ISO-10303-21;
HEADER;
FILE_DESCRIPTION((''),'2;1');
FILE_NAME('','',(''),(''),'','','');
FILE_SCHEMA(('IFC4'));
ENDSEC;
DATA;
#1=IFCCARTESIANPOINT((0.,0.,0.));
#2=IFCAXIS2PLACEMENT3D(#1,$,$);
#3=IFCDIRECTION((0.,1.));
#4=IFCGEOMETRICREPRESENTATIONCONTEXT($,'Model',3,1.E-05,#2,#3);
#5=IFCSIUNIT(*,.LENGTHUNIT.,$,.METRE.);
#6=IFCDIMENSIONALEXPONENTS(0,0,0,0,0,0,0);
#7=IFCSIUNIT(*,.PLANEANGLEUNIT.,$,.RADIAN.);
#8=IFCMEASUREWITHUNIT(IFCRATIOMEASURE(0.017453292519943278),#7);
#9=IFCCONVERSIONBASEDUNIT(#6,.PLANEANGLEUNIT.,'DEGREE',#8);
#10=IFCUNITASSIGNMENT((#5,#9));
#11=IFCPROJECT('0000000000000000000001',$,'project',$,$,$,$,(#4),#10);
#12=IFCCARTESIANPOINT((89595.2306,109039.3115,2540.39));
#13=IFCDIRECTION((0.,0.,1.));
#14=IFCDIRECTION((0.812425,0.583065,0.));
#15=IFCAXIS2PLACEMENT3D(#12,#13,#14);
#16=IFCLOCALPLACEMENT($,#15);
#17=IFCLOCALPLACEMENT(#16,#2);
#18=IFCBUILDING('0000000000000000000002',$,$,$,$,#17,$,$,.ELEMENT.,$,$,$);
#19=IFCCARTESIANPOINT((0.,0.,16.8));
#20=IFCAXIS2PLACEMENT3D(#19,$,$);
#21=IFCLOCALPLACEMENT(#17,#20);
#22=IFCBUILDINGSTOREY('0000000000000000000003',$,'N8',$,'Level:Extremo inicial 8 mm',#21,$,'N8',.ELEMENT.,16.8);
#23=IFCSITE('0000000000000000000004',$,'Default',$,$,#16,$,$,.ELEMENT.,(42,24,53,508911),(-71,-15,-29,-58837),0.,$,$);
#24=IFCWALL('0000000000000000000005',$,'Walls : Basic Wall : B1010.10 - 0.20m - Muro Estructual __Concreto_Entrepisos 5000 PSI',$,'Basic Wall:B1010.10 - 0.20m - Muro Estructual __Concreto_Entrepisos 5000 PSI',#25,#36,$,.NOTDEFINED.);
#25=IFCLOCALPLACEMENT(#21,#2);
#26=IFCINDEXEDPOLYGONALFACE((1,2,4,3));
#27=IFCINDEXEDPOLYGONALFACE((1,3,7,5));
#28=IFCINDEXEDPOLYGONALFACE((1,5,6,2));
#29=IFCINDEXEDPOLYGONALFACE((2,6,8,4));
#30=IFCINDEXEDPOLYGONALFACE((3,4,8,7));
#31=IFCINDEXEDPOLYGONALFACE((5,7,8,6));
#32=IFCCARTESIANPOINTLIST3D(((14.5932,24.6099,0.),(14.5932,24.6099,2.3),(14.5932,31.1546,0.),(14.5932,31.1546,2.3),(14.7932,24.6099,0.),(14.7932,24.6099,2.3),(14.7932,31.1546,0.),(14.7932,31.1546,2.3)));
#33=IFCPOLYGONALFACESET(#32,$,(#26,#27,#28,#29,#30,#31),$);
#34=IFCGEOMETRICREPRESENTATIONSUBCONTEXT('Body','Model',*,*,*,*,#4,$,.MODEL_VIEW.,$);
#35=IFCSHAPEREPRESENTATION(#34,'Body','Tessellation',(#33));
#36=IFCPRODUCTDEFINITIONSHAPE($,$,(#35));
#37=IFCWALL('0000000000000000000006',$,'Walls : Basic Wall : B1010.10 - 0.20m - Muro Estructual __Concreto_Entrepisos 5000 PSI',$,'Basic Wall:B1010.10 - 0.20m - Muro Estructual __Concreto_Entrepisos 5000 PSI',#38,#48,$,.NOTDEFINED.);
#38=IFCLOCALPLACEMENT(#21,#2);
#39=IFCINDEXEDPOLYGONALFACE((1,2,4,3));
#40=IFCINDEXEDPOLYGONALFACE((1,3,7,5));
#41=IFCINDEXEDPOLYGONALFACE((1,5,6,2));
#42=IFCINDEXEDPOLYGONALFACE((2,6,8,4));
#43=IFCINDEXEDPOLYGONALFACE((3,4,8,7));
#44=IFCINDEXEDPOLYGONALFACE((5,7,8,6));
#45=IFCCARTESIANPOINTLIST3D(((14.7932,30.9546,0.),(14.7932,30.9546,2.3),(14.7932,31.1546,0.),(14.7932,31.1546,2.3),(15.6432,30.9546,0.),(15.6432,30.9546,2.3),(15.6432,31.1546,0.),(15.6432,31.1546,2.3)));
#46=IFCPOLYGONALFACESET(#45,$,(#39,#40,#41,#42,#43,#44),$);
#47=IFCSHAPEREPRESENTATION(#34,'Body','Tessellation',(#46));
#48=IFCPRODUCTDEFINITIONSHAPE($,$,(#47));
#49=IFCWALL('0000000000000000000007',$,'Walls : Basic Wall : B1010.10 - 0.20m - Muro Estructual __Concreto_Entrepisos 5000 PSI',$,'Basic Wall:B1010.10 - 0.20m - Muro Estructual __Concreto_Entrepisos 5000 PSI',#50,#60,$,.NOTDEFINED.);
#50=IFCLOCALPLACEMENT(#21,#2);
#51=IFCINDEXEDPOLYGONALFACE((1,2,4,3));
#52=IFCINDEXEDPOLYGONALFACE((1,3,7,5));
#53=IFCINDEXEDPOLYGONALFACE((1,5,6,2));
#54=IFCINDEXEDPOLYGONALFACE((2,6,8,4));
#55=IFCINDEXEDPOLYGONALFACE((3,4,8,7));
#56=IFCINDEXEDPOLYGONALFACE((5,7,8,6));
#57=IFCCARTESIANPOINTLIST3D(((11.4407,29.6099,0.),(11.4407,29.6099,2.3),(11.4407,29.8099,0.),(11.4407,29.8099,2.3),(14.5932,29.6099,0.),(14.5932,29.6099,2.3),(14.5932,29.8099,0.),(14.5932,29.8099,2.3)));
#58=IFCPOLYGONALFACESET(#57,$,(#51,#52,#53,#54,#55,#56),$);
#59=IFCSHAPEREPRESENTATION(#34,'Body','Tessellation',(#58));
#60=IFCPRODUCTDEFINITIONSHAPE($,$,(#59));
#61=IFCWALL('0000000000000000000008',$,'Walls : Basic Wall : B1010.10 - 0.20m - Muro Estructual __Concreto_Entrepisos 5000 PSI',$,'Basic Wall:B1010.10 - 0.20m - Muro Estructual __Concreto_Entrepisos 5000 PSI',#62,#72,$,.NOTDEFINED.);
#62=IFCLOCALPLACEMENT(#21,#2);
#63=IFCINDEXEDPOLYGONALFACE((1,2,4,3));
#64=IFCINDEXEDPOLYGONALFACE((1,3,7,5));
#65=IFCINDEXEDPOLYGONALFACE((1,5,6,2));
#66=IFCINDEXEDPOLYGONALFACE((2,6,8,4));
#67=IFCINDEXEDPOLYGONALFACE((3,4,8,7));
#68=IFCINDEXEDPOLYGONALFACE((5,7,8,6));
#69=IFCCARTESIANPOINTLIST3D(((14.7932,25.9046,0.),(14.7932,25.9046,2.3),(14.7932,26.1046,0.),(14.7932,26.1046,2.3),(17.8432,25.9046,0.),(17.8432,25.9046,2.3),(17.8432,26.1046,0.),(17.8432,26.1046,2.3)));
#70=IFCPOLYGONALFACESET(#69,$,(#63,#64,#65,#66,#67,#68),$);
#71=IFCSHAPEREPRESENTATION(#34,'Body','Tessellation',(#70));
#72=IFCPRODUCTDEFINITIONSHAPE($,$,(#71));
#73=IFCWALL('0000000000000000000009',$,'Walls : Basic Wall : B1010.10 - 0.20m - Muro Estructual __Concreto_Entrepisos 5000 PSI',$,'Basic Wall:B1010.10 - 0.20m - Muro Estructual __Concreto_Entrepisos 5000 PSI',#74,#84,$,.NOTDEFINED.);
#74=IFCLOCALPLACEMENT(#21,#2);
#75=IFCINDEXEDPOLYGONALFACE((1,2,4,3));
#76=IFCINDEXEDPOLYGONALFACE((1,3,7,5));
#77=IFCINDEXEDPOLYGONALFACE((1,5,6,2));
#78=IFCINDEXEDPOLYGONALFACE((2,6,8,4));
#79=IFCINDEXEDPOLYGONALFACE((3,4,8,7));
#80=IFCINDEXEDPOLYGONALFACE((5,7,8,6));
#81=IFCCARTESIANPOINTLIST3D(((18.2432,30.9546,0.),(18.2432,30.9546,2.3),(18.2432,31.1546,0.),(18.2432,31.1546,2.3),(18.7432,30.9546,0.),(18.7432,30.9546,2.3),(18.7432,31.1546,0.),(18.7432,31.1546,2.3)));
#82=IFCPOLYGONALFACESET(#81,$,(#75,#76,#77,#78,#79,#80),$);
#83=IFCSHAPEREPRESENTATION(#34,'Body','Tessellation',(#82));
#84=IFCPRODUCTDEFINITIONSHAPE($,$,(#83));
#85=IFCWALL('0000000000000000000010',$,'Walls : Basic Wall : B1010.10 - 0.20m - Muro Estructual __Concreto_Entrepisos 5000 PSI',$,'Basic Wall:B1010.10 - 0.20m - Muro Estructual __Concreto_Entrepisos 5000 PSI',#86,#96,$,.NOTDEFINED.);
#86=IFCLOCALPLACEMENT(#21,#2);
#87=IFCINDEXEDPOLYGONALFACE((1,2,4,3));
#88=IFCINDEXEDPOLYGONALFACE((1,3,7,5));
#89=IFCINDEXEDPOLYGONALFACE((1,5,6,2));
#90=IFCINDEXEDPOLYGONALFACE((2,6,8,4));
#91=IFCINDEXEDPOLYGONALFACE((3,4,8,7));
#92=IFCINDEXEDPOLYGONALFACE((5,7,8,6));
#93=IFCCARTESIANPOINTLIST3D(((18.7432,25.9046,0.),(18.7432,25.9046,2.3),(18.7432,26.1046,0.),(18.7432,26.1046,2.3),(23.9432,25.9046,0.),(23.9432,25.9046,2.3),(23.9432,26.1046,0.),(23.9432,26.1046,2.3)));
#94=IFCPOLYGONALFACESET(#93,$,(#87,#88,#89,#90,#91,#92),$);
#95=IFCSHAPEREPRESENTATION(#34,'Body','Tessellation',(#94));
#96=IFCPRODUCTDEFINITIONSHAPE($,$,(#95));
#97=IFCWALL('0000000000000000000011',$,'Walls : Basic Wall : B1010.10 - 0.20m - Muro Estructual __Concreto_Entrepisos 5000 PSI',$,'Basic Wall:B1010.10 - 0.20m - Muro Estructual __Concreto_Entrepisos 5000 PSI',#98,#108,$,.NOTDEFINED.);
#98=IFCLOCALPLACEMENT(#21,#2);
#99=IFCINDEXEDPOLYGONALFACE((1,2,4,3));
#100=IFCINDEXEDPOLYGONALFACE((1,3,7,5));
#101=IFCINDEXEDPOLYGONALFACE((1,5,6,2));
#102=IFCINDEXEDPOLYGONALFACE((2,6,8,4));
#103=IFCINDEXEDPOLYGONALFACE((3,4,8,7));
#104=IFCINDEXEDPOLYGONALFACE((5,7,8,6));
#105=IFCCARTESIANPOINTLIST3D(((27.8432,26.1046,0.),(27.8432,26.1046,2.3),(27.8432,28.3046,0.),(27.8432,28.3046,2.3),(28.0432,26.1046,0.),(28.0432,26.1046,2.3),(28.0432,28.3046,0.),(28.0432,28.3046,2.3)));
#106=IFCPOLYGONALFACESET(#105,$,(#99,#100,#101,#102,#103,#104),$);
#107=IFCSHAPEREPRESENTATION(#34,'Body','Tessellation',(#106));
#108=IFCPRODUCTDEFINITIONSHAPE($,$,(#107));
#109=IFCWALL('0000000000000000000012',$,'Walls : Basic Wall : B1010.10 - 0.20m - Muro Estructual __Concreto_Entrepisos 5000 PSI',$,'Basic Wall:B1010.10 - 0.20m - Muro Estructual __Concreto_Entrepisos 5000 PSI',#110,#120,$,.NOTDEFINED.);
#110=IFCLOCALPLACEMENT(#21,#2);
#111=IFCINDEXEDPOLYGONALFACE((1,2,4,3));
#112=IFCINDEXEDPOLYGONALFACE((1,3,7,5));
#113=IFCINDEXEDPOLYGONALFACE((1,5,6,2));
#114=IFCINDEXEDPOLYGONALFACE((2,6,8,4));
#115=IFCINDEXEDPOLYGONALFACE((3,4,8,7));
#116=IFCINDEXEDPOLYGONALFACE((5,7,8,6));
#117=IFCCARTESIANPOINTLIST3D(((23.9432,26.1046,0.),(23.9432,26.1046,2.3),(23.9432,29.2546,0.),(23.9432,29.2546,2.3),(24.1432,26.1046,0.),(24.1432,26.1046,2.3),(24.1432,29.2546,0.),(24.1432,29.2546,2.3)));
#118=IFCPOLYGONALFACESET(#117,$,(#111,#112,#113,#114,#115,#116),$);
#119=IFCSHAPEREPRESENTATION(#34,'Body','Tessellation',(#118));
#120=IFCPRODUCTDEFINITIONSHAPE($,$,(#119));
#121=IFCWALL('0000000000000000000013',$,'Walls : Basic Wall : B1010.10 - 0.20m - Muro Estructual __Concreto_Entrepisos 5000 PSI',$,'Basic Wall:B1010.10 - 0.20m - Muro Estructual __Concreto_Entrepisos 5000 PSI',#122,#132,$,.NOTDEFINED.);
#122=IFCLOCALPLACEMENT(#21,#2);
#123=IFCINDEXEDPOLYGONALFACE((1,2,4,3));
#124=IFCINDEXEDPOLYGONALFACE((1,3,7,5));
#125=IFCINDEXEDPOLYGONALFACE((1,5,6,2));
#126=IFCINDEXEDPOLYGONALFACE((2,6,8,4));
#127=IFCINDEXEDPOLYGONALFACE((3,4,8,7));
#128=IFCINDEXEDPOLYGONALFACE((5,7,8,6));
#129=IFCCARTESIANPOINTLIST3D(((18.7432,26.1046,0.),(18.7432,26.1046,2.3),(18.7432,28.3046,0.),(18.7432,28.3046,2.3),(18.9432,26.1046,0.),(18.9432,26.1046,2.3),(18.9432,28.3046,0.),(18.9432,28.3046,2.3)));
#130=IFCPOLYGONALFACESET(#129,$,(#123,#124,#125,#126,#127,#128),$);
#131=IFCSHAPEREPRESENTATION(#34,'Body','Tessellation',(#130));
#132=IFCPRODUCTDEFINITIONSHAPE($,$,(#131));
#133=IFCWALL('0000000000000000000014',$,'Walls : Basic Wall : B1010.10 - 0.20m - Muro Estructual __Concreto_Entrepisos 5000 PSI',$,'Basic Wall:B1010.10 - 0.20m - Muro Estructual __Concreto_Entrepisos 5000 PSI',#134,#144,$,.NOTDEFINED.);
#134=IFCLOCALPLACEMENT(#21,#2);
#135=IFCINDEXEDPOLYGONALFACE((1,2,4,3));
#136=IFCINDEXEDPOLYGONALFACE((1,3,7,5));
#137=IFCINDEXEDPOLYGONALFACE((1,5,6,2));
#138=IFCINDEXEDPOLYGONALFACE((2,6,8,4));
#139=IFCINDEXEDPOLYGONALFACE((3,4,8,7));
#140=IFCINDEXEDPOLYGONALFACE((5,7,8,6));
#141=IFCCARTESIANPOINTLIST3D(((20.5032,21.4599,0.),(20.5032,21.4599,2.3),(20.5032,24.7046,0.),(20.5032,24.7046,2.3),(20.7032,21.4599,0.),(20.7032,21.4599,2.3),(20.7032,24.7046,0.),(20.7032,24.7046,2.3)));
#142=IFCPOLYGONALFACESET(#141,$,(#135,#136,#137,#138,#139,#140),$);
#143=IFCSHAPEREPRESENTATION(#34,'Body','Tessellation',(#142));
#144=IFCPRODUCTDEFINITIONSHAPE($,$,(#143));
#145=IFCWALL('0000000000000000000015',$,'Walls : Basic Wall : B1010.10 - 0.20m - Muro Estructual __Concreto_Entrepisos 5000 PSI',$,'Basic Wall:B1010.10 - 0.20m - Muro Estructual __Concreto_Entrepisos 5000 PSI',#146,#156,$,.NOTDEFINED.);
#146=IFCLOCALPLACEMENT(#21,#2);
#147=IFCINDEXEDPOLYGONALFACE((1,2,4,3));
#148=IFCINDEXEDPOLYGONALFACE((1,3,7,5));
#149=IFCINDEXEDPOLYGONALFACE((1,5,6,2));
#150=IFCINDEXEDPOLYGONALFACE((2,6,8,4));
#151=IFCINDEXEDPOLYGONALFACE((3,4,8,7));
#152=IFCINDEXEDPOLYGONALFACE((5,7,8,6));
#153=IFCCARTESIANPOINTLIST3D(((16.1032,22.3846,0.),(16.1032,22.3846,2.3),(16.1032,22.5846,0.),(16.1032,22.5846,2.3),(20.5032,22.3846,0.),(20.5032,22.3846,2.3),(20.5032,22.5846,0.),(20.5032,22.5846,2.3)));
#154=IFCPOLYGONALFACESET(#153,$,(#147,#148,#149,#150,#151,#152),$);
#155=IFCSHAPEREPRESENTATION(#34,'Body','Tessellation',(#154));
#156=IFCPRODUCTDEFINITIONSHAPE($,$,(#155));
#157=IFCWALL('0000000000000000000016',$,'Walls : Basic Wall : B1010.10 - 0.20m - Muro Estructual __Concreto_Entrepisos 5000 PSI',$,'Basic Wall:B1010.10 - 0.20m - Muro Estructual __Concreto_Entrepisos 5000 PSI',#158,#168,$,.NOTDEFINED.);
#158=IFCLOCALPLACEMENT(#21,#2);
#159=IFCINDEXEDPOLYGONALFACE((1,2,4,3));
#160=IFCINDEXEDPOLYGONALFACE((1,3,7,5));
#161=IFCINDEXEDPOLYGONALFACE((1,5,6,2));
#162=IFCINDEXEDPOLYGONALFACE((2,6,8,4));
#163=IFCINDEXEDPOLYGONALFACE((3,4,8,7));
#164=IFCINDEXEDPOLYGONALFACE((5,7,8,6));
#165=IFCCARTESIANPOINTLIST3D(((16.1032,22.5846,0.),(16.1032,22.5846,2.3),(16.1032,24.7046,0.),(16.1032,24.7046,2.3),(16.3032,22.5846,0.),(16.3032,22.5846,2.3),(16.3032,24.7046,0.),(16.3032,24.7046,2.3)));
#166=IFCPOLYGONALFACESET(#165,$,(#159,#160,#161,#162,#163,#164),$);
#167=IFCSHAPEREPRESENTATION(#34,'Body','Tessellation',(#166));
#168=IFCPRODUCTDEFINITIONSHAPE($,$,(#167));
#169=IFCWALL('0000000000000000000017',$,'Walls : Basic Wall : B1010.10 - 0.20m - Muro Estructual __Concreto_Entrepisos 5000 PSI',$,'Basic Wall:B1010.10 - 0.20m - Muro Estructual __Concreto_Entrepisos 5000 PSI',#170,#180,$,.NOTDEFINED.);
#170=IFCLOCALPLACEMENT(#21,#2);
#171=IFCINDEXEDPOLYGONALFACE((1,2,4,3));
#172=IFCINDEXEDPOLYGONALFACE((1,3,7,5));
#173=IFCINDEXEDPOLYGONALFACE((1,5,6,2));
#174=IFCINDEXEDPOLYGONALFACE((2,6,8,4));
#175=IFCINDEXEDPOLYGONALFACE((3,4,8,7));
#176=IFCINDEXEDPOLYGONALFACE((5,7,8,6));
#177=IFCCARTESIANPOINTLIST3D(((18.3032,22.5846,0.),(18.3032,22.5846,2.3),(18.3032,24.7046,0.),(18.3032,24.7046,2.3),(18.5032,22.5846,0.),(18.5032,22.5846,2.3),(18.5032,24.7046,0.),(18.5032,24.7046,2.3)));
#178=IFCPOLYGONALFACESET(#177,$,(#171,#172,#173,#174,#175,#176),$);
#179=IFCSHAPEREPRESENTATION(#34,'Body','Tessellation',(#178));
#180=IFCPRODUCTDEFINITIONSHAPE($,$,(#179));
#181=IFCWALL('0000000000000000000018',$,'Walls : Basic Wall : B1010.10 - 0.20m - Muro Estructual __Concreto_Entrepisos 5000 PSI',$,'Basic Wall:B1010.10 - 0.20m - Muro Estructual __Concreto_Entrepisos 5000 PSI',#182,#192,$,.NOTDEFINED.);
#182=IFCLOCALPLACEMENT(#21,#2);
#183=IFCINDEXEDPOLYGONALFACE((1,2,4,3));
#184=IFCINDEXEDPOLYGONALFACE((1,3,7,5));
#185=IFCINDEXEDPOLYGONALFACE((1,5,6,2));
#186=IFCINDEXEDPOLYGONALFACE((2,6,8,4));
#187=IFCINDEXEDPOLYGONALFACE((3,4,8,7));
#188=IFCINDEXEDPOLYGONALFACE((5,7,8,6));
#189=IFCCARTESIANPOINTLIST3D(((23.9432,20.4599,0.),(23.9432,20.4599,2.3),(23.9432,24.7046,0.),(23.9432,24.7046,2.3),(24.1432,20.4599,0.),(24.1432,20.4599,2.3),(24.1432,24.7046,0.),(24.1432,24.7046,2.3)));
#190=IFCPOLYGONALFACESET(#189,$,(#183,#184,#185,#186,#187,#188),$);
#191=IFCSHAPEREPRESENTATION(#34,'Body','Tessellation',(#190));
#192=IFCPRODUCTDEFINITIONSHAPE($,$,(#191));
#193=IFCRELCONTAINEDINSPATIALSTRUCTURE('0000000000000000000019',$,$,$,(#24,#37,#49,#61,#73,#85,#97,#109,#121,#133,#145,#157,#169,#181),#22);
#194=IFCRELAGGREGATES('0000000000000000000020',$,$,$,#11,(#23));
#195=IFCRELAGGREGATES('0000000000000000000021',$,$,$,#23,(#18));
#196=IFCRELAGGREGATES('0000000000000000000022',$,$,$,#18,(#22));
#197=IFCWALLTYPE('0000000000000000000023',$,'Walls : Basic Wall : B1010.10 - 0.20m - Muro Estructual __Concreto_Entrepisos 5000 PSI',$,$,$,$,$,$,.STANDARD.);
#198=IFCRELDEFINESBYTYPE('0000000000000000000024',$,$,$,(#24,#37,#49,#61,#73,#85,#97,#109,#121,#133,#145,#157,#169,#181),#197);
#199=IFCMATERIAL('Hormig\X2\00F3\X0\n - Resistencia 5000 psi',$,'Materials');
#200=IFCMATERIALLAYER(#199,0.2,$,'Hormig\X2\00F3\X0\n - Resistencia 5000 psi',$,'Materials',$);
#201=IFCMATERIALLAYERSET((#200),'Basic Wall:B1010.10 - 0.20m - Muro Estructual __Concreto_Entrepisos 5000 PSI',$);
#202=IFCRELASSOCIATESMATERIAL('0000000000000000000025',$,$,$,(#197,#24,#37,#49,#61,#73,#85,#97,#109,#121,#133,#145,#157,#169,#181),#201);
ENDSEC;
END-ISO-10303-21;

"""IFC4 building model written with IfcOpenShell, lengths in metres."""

from ifc_helpers import new_model, entity, si_unit, converted_unit, direction, frame, frame_2d, origin, place, context, subcontext, project, spatial, rectangle, extrude, material, layer, layer_set, layer_usage, type_object, element, save


model = new_model("IFC4")

# Units and contexts
model_context = context("Model", 3, precision=1e-05, world=origin(), true_north=direction((0.0, 1.0)))
body_context = subcontext(model_context, "Body", "Model", "MODEL_VIEW")
ifc_project = project(units=[si_unit("LENGTHUNIT", "METRE"), converted_unit("PLANEANGLEUNIT", "DEGREE", entity("IfcRatioMeasure", 0.017453292519943278), si_unit("PLANEANGLEUNIT", "RADIAN"), dimensions=[0, 0, 0, 0, 0, 0, 0])], contexts=[model_context])

# Site, building, storey
site_placement = place(None, frame((89595.2306, 109039.3115, 2540.39), z_axis=(0.0, 0.0, 1.0), x_axis=(0.812425, 0.583065, 0.0)))
site = spatial("IfcSite", under=ifc_project, at=site_placement, Name="Default", CompositionType="ELEMENT", RefLatitude=(42, 24, 53, 508911), RefLongitude=(-71, -15, -29, -58837), RefElevation=0.0)
building_placement = place(site_placement, origin())
building = spatial("IfcBuilding", under=site, at=building_placement, CompositionType="ELEMENT")
storey_placement = place(building_placement, frame((0.0, 0.0, 16.8)))
storey = spatial("IfcBuildingStorey", under=building, at=storey_placement, Name="N8", ObjectType="Level:Extremo inicial 8 mm", LongName="N8", CompositionType="ELEMENT", Elevation=16.8)

# Walls
ifc_material_1 = material(Name="Hormigón - Resistencia 5000 psi", Category="Materials")
ifc_layer_1 = layer(ifc_material_1, 0.2, Name="Hormigón - Resistencia 5000 psi", Category="Materials")
ifc_layer_set_1 = layer_set([ifc_layer_1], Name="Basic Wall:B1010.10 - 0.20m - Muro Estructual __Concreto_Entrepisos 5000 PSI")
ifc_layer_usage_1 = layer_usage(ifc_layer_set_1, "AXIS2", "NEGATIVE", 0.1)
wall_type_1 = type_object("IfcWallType", Name="Walls : Basic Wall : B1010.10 - 0.20m - Muro Estructual __Concreto_Entrepisos 5000 PSI", PredefinedType="STANDARD", material=ifc_layer_set_1)
wall_1_placement = place(storey_placement, frame((14.6932, 24.6099, 0.0), z_axis=(0.0, 0.0, 1.0), x_axis=(0.0, 1.0, 0.0)))
element("IfcWall", 1, at=wall_1_placement, inside=storey, type_object=wall_type_1, material=ifc_layer_usage_1, Name="Walls : Basic Wall : B1010.10 - 0.20m - Muro Estructual __Concreto_Entrepisos 5000 PSI", ObjectType="Basic Wall:B1010.10 - 0.20m - Muro Estructual __Concreto_Entrepisos 5000 PSI", PredefinedType="NOTDEFINED", context=body_context, shape_type="SweptSolid", body=[
    extrude(rectangle(XDim=6.5447, YDim=0.2, at=frame_2d((3.2724, 0.0), x_axis=(-1.0, 0.0))), origin(), (0.0, 0.0, 1.0), 2.3),
])
ifc_layer_usage_2 = layer_usage(ifc_layer_set_1, "AXIS2", "NEGATIVE", 0.1)
wall_2_placement = place(storey_placement, frame((15.6432, 31.0546, 0.0), z_axis=(0.0, 0.0, 1.0), x_axis=(-1.0, 0.0, 0.0)))
element("IfcWall", 2, at=wall_2_placement, inside=storey, type_object=wall_type_1, material=ifc_layer_usage_2, Name="Walls : Basic Wall : B1010.10 - 0.20m - Muro Estructual __Concreto_Entrepisos 5000 PSI", ObjectType="Basic Wall:B1010.10 - 0.20m - Muro Estructual __Concreto_Entrepisos 5000 PSI", PredefinedType="NOTDEFINED", context=body_context, shape_type="SweptSolid", body=[
    extrude(rectangle(XDim=0.85, YDim=0.2, at=frame_2d((0.425, 0.0), x_axis=(-1.0, 0.0))), origin(), (0.0, 0.0, 1.0), 2.3),
])
ifc_layer_usage_3 = layer_usage(ifc_layer_set_1, "AXIS2", "NEGATIVE", 0.1)
wall_3_placement = place(storey_placement, frame((11.4407, 29.7099, 0.0)))
element("IfcWall", 3, at=wall_3_placement, inside=storey, type_object=wall_type_1, material=ifc_layer_usage_3, Name="Walls : Basic Wall : B1010.10 - 0.20m - Muro Estructual __Concreto_Entrepisos 5000 PSI", ObjectType="Basic Wall:B1010.10 - 0.20m - Muro Estructual __Concreto_Entrepisos 5000 PSI", PredefinedType="NOTDEFINED", context=body_context, shape_type="SweptSolid", body=[
    extrude(rectangle(XDim=3.1525, YDim=0.2, at=frame_2d((1.5763, 0.0), x_axis=(-1.0, 0.0))), origin(), (0.0, 0.0, 1.0), 2.3),
])
ifc_layer_usage_4 = layer_usage(ifc_layer_set_1, "AXIS2", "NEGATIVE", 0.1)
wall_4_placement = place(storey_placement, frame((17.8432, 26.0046, 0.0), z_axis=(0.0, 0.0, 1.0), x_axis=(-1.0, 0.0, 0.0)))
element("IfcWall", 4, at=wall_4_placement, inside=storey, type_object=wall_type_1, material=ifc_layer_usage_4, Name="Walls : Basic Wall : B1010.10 - 0.20m - Muro Estructual __Concreto_Entrepisos 5000 PSI", ObjectType="Basic Wall:B1010.10 - 0.20m - Muro Estructual __Concreto_Entrepisos 5000 PSI", PredefinedType="NOTDEFINED", context=body_context, shape_type="SweptSolid", body=[
    extrude(rectangle(XDim=3.05, YDim=0.2, at=frame_2d((1.525, 0.0), x_axis=(-1.0, 0.0))), origin(), (0.0, 0.0, 1.0), 2.3),
])
ifc_layer_usage_5 = layer_usage(ifc_layer_set_1, "AXIS2", "NEGATIVE", 0.1)
wall_5_placement = place(storey_placement, frame((18.7432, 31.0546, 0.0), z_axis=(0.0, 0.0, 1.0), x_axis=(-1.0, 0.0, 0.0)))
element("IfcWall", 5, at=wall_5_placement, inside=storey, type_object=wall_type_1, material=ifc_layer_usage_5, Name="Walls : Basic Wall : B1010.10 - 0.20m - Muro Estructual __Concreto_Entrepisos 5000 PSI", ObjectType="Basic Wall:B1010.10 - 0.20m - Muro Estructual __Concreto_Entrepisos 5000 PSI", PredefinedType="NOTDEFINED", context=body_context, shape_type="SweptSolid", body=[
    extrude(rectangle(XDim=0.5, YDim=0.2, at=frame_2d((0.25, 0.0), x_axis=(-1.0, 0.0))), origin(), (0.0, 0.0, 1.0), 2.3),
])
ifc_layer_usage_6 = layer_usage(ifc_layer_set_1, "AXIS2", "NEGATIVE", 0.1)
wall_6_placement = place(storey_placement, frame((18.7432, 26.0046, 0.0)))
element("IfcWall", 6, at=wall_6_placement, inside=storey, type_object=wall_type_1, material=ifc_layer_usage_6, Name="Walls : Basic Wall : B1010.10 - 0.20m - Muro Estructual __Concreto_Entrepisos 5000 PSI", ObjectType="Basic Wall:B1010.10 - 0.20m - Muro Estructual __Concreto_Entrepisos 5000 PSI", PredefinedType="NOTDEFINED", context=body_context, shape_type="SweptSolid", body=[
    extrude(rectangle(XDim=5.2, YDim=0.2, at=frame_2d((2.6, 0.0), x_axis=(-1.0, 0.0))), origin(), (0.0, 0.0, 1.0), 2.3),
])
ifc_layer_usage_7 = layer_usage(ifc_layer_set_1, "AXIS2", "NEGATIVE", 0.1)
wall_7_placement = place(storey_placement, frame((27.9432, 28.3046, 0.0), z_axis=(0.0, 0.0, 1.0), x_axis=(0.0, -1.0, 0.0)))
element("IfcWall", 7, at=wall_7_placement, inside=storey, type_object=wall_type_1, material=ifc_layer_usage_7, Name="Walls : Basic Wall : B1010.10 - 0.20m - Muro Estructual __Concreto_Entrepisos 5000 PSI", ObjectType="Basic Wall:B1010.10 - 0.20m - Muro Estructual __Concreto_Entrepisos 5000 PSI", PredefinedType="NOTDEFINED", context=body_context, shape_type="SweptSolid", body=[
    extrude(rectangle(XDim=2.2, YDim=0.2, at=frame_2d((1.1, 0.0), x_axis=(-1.0, 0.0))), origin(), (0.0, 0.0, 1.0), 2.3),
])
ifc_layer_usage_8 = layer_usage(ifc_layer_set_1, "AXIS2", "NEGATIVE", 0.1)
wall_8_placement = place(storey_placement, frame((24.0432, 26.1046, 0.0), z_axis=(0.0, 0.0, 1.0), x_axis=(0.0, 1.0, 0.0)))
element("IfcWall", 8, at=wall_8_placement, inside=storey, type_object=wall_type_1, material=ifc_layer_usage_8, Name="Walls : Basic Wall : B1010.10 - 0.20m - Muro Estructual __Concreto_Entrepisos 5000 PSI", ObjectType="Basic Wall:B1010.10 - 0.20m - Muro Estructual __Concreto_Entrepisos 5000 PSI", PredefinedType="NOTDEFINED", context=body_context, shape_type="SweptSolid", body=[
    extrude(rectangle(XDim=3.15, YDim=0.2, at=frame_2d((1.575, 0.0), x_axis=(-1.0, 0.0))), origin(), (0.0, 0.0, 1.0), 2.3),
])
ifc_layer_usage_9 = layer_usage(ifc_layer_set_1, "AXIS2", "NEGATIVE", 0.1)
wall_9_placement = place(storey_placement, frame((18.8432, 28.3046, 0.0), z_axis=(0.0, 0.0, 1.0), x_axis=(0.0, -1.0, 0.0)))
element("IfcWall", 9, at=wall_9_placement, inside=storey, type_object=wall_type_1, material=ifc_layer_usage_9, Name="Walls : Basic Wall : B1010.10 - 0.20m - Muro Estructual __Concreto_Entrepisos 5000 PSI", ObjectType="Basic Wall:B1010.10 - 0.20m - Muro Estructual __Concreto_Entrepisos 5000 PSI", PredefinedType="NOTDEFINED", context=body_context, shape_type="SweptSolid", body=[
    extrude(rectangle(XDim=2.2, YDim=0.2, at=frame_2d((1.1, 0.0), x_axis=(-1.0, 0.0))), origin(), (0.0, 0.0, 1.0), 2.3),
])
ifc_layer_usage_10 = layer_usage(ifc_layer_set_1, "AXIS2", "NEGATIVE", 0.1)
wall_10_placement = place(storey_placement, frame((20.6032, 21.4599, 0.0), z_axis=(0.0, 0.0, 1.0), x_axis=(0.0, 1.0, 0.0)))
element("IfcWall", 10, at=wall_10_placement, inside=storey, type_object=wall_type_1, material=ifc_layer_usage_10, Name="Walls : Basic Wall : B1010.10 - 0.20m - Muro Estructual __Concreto_Entrepisos 5000 PSI", ObjectType="Basic Wall:B1010.10 - 0.20m - Muro Estructual __Concreto_Entrepisos 5000 PSI", PredefinedType="NOTDEFINED", context=body_context, shape_type="SweptSolid", body=[
    extrude(rectangle(XDim=3.2447, YDim=0.2, at=frame_2d((1.6224, 0.0), x_axis=(-1.0, 0.0))), origin(), (0.0, 0.0, 1.0), 2.3),
])
ifc_layer_usage_11 = layer_usage(ifc_layer_set_1, "AXIS2", "NEGATIVE", 0.1)
wall_11_placement = place(storey_placement, frame((20.5032, 22.4846, 0.0), z_axis=(0.0, 0.0, 1.0), x_axis=(-1.0, 0.0, 0.0)))
element("IfcWall", 11, at=wall_11_placement, inside=storey, type_object=wall_type_1, material=ifc_layer_usage_11, Name="Walls : Basic Wall : B1010.10 - 0.20m - Muro Estructual __Concreto_Entrepisos 5000 PSI", ObjectType="Basic Wall:B1010.10 - 0.20m - Muro Estructual __Concreto_Entrepisos 5000 PSI", PredefinedType="NOTDEFINED", context=body_context, shape_type="SweptSolid", body=[
    extrude(rectangle(XDim=4.4, YDim=0.2, at=frame_2d((2.2, 0.0), x_axis=(-1.0, 0.0))), origin(), (0.0, 0.0, 1.0), 2.3),
])
ifc_layer_usage_12 = layer_usage(ifc_layer_set_1, "AXIS2", "NEGATIVE", 0.1)
wall_12_placement = place(storey_placement, frame((16.2032, 22.5846, 0.0), z_axis=(0.0, 0.0, 1.0), x_axis=(0.0, 1.0, 0.0)))
element("IfcWall", 12, at=wall_12_placement, inside=storey, type_object=wall_type_1, material=ifc_layer_usage_12, Name="Walls : Basic Wall : B1010.10 - 0.20m - Muro Estructual __Concreto_Entrepisos 5000 PSI", ObjectType="Basic Wall:B1010.10 - 0.20m - Muro Estructual __Concreto_Entrepisos 5000 PSI", PredefinedType="NOTDEFINED", context=body_context, shape_type="SweptSolid", body=[
    extrude(rectangle(XDim=2.12, YDim=0.2, at=frame_2d((1.06, 0.0), x_axis=(-1.0, 0.0))), origin(), (0.0, 0.0, 1.0), 2.3),
])
ifc_layer_usage_13 = layer_usage(ifc_layer_set_1, "AXIS2", "NEGATIVE", 0.1)
wall_13_placement = place(storey_placement, frame((18.4032, 24.7046, 0.0), z_axis=(0.0, 0.0, 1.0), x_axis=(0.0, -1.0, 0.0)))
element("IfcWall", 13, at=wall_13_placement, inside=storey, type_object=wall_type_1, material=ifc_layer_usage_13, Name="Walls : Basic Wall : B1010.10 - 0.20m - Muro Estructual __Concreto_Entrepisos 5000 PSI", ObjectType="Basic Wall:B1010.10 - 0.20m - Muro Estructual __Concreto_Entrepisos 5000 PSI", PredefinedType="NOTDEFINED", context=body_context, shape_type="SweptSolid", body=[
    extrude(rectangle(XDim=2.12, YDim=0.2, at=frame_2d((1.06, 0.0), x_axis=(-1.0, 0.0))), origin(), (0.0, 0.0, 1.0), 2.3),
])
ifc_layer_usage_14 = layer_usage(ifc_layer_set_1, "AXIS2", "NEGATIVE", 0.1)
wall_14_placement = place(storey_placement, frame((24.0432, 20.4599, 0.0), z_axis=(0.0, 0.0, 1.0), x_axis=(0.0, 1.0, 0.0)))
element("IfcWall", 14, at=wall_14_placement, inside=storey, type_object=wall_type_1, material=ifc_layer_usage_14, Name="Walls : Basic Wall : B1010.10 - 0.20m - Muro Estructual __Concreto_Entrepisos 5000 PSI", ObjectType="Basic Wall:B1010.10 - 0.20m - Muro Estructual __Concreto_Entrepisos 5000 PSI", PredefinedType="NOTDEFINED", context=body_context, shape_type="SweptSolid", body=[
    extrude(rectangle(XDim=4.2447, YDim=0.2, at=frame_2d((2.1224, 0.0), x_axis=(-1.0, 0.0))), origin(), (0.0, 0.0, 1.0), 2.3),
])

save(model, "model.ifc")
